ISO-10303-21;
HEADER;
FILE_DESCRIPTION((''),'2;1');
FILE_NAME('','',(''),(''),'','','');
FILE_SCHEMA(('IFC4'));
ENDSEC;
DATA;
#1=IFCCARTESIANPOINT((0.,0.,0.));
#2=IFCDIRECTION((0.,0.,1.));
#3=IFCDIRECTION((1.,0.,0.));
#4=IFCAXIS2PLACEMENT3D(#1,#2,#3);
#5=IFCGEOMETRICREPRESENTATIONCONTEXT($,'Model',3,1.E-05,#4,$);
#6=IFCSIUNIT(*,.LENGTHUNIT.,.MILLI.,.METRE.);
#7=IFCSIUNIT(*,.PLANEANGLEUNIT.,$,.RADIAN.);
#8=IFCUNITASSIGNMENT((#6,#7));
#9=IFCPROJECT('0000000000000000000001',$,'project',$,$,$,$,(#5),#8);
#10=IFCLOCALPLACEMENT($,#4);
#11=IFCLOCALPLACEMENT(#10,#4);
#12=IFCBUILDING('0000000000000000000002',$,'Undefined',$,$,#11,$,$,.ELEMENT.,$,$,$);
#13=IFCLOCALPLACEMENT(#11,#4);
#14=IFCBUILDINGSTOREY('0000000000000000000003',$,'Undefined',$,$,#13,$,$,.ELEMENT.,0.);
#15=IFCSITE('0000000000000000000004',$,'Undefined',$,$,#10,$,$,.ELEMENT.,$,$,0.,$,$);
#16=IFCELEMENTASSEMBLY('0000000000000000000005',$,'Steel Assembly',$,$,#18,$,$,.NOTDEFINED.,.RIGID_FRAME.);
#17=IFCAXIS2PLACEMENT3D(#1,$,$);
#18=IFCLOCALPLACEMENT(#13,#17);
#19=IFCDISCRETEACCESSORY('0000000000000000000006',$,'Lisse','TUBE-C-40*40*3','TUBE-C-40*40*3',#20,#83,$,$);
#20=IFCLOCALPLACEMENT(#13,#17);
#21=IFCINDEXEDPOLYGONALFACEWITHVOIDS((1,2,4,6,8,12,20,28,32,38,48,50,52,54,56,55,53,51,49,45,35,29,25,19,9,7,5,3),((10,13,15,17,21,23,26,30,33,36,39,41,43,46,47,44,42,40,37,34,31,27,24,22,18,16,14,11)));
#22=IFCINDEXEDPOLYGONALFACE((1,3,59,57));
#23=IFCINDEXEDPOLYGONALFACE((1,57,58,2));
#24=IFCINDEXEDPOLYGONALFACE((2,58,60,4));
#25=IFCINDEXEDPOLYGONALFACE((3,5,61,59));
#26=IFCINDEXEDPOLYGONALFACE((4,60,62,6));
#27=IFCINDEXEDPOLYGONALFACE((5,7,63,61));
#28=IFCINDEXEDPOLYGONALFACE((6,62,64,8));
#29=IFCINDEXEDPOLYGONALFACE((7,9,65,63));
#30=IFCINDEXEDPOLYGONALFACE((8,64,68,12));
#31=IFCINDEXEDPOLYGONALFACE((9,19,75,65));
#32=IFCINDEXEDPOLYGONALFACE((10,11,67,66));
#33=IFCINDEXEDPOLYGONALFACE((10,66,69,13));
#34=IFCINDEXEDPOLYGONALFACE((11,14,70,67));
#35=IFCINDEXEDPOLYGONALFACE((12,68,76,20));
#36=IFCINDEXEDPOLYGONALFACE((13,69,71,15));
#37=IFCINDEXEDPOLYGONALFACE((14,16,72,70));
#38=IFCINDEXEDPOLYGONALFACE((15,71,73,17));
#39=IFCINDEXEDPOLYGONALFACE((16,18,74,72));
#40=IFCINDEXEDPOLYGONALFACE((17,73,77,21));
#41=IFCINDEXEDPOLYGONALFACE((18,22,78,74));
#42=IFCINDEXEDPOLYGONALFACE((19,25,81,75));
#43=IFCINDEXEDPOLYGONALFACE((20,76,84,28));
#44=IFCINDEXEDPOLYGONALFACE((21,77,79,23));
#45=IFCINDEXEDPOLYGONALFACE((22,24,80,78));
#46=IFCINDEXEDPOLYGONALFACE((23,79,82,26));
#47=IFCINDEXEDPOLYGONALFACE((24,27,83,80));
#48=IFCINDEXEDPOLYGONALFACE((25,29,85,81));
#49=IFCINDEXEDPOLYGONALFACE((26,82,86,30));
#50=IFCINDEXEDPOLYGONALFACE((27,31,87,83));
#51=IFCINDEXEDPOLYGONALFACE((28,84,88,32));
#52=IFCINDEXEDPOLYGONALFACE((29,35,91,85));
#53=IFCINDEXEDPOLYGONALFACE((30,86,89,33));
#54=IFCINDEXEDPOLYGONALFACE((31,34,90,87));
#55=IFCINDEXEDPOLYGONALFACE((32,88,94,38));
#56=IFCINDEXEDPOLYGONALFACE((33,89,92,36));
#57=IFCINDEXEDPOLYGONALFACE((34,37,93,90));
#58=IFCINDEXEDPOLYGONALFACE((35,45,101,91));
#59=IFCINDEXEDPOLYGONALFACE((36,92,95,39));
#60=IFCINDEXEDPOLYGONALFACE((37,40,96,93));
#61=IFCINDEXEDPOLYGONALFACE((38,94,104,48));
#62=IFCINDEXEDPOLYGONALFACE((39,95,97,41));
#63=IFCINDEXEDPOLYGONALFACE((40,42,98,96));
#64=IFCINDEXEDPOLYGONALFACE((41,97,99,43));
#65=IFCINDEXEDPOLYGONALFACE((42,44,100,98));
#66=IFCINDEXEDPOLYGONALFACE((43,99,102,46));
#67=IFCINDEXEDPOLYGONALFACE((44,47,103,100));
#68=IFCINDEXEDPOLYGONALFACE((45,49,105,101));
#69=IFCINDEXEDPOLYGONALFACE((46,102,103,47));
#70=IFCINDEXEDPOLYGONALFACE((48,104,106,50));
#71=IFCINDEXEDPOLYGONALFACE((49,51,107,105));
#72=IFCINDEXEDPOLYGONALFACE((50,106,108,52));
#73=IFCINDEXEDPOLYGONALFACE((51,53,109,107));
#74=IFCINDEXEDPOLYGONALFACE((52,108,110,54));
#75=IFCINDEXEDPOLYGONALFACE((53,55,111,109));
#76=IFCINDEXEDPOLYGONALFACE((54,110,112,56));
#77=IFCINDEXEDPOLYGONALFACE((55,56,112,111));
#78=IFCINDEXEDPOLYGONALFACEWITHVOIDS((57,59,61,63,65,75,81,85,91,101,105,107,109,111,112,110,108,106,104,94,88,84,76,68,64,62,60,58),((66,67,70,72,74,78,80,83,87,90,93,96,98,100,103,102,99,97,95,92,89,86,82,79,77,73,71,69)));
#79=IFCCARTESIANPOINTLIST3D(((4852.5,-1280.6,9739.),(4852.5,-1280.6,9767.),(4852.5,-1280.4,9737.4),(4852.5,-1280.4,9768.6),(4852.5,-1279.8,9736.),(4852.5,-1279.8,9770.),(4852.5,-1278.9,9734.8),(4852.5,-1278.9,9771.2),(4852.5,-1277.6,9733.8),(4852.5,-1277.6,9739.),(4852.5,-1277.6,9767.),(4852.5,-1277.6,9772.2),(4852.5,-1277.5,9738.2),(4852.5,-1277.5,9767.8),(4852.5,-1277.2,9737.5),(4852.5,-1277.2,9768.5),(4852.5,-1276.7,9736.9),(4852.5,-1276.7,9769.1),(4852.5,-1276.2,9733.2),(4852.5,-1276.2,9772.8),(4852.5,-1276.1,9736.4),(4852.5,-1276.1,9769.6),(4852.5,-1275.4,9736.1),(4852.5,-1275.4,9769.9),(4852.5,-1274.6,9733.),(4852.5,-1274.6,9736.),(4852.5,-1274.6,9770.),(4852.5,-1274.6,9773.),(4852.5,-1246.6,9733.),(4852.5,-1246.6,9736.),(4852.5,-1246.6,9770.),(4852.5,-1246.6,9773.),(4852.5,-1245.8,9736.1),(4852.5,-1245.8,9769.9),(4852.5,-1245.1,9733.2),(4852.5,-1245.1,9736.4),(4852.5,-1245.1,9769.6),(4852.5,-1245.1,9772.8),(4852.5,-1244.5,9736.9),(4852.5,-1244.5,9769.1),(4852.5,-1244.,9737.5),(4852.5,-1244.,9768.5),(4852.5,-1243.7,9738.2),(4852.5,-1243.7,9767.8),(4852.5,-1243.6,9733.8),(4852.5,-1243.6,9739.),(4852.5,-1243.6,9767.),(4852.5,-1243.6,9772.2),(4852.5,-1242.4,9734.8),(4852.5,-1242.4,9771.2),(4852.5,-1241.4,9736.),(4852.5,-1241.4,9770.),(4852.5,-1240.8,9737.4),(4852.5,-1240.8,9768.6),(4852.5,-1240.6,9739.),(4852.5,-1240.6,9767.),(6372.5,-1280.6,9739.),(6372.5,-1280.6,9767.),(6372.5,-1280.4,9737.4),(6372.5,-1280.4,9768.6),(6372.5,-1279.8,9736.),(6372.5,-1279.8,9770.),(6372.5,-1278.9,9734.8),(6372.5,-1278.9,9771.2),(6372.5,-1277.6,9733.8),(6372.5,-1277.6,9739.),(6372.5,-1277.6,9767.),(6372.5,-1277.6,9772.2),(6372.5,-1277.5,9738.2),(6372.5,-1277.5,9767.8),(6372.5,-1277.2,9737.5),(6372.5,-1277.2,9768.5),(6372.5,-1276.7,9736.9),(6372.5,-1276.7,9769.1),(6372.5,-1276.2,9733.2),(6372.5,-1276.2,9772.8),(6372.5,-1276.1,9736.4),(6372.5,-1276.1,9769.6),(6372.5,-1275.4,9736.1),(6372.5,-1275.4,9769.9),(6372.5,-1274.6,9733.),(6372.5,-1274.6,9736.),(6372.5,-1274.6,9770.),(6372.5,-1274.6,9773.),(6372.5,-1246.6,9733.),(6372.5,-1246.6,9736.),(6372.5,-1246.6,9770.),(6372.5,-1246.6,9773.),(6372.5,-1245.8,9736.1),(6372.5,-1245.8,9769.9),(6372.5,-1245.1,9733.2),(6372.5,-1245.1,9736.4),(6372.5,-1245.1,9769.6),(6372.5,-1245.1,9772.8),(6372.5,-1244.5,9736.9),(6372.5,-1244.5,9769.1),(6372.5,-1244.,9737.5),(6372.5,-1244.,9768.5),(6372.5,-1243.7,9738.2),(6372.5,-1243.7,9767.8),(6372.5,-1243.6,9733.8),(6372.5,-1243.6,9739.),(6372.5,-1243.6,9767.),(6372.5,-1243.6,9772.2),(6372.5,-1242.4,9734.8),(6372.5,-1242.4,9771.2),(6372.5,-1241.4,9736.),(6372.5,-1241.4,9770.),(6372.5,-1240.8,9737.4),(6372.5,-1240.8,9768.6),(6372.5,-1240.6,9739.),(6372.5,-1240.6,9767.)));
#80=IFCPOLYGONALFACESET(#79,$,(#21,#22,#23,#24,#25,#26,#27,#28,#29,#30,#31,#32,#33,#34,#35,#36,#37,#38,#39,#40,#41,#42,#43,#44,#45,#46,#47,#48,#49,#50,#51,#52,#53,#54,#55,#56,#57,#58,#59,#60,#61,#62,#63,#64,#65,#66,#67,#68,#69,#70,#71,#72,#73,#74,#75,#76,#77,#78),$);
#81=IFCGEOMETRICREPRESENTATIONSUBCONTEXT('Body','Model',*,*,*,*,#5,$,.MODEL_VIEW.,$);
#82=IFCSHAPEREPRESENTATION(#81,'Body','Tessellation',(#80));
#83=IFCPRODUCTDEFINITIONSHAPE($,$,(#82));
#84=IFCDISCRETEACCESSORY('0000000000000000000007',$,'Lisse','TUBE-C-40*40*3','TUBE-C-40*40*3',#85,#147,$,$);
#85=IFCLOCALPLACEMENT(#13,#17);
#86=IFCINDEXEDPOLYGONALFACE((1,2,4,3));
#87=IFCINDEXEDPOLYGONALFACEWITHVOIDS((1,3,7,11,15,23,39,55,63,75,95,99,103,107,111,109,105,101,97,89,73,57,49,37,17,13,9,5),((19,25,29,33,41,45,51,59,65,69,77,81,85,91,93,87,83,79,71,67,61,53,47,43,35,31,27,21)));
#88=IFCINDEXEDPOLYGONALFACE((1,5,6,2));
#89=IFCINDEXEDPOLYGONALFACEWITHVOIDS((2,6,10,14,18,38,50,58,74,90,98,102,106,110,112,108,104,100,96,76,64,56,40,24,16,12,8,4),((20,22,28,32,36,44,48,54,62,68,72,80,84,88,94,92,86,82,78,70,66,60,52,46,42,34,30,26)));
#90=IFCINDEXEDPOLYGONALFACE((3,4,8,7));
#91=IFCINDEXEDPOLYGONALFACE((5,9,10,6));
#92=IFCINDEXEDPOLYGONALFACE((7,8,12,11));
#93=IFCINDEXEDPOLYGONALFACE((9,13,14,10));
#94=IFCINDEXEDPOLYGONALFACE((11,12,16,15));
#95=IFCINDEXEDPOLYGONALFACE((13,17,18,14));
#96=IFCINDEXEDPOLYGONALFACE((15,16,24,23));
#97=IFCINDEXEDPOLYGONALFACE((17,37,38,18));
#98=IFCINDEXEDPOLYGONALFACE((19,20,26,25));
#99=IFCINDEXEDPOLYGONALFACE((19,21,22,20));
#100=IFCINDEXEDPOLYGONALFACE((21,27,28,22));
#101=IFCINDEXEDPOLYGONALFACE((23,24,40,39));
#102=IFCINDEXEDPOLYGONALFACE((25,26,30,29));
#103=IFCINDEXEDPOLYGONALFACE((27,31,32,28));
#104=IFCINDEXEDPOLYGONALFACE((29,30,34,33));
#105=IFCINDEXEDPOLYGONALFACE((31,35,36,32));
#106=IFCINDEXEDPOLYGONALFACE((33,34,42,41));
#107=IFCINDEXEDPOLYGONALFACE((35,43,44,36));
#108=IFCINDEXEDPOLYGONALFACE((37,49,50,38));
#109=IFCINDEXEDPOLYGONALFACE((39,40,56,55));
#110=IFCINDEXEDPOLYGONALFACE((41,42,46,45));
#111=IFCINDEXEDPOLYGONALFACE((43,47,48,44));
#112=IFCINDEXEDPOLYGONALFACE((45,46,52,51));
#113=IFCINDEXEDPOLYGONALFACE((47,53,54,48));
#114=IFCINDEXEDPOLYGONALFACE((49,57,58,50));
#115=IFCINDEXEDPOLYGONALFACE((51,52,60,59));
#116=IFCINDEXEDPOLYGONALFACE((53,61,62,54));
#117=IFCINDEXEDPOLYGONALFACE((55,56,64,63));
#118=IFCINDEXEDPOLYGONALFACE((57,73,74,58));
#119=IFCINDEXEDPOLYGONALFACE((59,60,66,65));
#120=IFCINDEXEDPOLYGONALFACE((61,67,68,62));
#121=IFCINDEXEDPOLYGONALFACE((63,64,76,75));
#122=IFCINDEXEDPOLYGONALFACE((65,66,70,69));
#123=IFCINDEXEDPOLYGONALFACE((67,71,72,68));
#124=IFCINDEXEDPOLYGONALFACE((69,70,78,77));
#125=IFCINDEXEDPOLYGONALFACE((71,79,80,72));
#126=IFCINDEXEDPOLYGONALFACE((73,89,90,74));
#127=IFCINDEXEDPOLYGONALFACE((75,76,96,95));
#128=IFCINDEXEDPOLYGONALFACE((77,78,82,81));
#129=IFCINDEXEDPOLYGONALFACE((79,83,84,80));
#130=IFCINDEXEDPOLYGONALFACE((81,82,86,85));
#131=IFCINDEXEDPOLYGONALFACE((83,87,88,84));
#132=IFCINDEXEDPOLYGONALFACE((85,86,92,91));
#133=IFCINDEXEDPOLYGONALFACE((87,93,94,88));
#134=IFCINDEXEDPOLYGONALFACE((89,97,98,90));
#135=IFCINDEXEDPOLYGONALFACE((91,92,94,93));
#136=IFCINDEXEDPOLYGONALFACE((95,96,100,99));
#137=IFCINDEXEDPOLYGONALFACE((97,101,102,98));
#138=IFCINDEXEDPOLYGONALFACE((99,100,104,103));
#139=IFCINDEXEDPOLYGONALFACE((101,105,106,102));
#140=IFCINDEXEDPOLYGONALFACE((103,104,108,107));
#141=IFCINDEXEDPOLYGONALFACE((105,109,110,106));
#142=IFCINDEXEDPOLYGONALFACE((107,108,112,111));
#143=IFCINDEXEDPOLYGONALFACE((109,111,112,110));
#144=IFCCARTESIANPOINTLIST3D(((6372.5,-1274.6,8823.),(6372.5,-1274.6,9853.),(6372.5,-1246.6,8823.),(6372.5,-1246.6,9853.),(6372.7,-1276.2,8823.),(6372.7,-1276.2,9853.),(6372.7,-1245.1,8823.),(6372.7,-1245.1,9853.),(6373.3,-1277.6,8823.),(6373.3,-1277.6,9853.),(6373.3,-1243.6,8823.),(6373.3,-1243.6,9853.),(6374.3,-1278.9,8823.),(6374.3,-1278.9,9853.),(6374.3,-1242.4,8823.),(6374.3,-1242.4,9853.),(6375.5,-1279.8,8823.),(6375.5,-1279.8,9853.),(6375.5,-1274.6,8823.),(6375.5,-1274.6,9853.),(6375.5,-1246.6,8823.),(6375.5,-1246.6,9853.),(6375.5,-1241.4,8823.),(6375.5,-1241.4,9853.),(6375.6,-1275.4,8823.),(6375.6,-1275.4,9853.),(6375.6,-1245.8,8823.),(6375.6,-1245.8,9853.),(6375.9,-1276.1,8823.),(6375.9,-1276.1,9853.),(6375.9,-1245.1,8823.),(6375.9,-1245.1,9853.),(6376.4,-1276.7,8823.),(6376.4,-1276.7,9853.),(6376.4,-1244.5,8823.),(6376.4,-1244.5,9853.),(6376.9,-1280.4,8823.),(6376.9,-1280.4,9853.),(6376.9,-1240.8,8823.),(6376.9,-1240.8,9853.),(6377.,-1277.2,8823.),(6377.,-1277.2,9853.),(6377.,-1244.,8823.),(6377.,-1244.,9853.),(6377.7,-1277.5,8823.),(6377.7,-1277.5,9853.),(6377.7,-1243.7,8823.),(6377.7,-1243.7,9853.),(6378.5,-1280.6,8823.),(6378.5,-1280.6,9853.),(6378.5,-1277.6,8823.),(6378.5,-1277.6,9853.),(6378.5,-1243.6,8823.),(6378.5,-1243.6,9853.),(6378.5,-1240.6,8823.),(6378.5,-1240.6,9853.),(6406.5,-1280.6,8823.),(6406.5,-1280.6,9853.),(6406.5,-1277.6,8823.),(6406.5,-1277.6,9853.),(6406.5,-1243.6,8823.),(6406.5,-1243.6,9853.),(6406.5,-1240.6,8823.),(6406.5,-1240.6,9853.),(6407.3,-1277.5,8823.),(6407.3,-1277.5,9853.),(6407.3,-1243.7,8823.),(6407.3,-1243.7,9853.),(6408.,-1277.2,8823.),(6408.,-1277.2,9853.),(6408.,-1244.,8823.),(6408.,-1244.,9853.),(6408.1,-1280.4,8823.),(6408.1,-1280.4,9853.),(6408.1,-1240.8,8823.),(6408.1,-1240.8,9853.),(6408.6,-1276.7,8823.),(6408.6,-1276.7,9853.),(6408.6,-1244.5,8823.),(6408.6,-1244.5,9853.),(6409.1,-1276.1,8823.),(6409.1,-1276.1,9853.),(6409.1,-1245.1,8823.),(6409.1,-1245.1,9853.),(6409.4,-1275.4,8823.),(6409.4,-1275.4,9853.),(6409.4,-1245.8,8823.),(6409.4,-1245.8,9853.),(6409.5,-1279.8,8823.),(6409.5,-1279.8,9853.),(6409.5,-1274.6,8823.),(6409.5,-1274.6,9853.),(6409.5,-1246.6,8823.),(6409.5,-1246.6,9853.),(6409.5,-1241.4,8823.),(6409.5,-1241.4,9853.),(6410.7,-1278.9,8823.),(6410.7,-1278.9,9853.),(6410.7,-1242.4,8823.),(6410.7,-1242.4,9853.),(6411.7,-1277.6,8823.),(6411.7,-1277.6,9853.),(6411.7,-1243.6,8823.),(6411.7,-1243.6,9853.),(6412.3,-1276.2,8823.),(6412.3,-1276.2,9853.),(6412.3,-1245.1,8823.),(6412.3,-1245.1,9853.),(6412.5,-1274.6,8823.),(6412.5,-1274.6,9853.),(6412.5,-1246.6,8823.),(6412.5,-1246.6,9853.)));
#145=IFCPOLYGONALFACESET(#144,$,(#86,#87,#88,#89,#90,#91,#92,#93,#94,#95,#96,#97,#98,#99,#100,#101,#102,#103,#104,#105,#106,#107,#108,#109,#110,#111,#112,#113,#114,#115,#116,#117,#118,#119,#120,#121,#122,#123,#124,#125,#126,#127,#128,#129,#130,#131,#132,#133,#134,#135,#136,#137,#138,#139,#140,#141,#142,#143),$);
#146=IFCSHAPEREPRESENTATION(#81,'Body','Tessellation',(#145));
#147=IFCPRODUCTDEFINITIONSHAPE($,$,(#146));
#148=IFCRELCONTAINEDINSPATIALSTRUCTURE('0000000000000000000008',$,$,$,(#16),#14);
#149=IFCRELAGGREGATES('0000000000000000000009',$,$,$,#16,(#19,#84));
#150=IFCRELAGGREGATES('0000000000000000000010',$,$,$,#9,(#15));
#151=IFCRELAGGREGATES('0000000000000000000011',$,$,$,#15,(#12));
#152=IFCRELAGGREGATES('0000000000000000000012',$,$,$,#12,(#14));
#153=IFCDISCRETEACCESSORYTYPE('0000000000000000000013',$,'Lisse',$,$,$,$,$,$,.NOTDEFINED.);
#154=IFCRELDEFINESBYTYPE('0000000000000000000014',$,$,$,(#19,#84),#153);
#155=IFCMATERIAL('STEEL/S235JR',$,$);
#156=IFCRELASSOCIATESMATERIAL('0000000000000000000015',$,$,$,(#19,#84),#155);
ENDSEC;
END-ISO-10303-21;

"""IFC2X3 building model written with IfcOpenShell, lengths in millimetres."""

from ifc_helpers import new_model, si_unit, frame, origin_with_axes, origin_2d_with_axis, place, context, subcontext, project, spatial, hollow_rectangle, extrude, material, type_object, element, aggregate, save


model = new_model("IFC2X3")

# Units and contexts
model_context = context("Model", 3, precision=1e-05, world=origin_with_axes())
body_context = subcontext(model_context, "Body", "Model", "MODEL_VIEW")
ifc_project = project(units=[si_unit("LENGTHUNIT", "METRE", prefix="MILLI"), si_unit("PLANEANGLEUNIT", "RADIAN")], contexts=[model_context])

# Site, building, storey
site_placement = place(None, origin_with_axes())
site = spatial("IfcSite", under=ifc_project, at=site_placement, Name="Undefined", CompositionType="ELEMENT", RefElevation=0.0)
building_placement = place(site_placement, origin_with_axes())
building = spatial("IfcBuilding", under=site, at=building_placement, Name="Undefined", CompositionType="ELEMENT")
storey_placement = place(building_placement, origin_with_axes())
storey = spatial("IfcBuildingStorey", under=building, at=storey_placement, Name="Undefined", CompositionType="ELEMENT", Elevation=0.0)

# Element assembly
assembly_1_placement = place(storey_placement, origin_with_axes())
assembly_1 = element("IfcElementAssembly", 1, at=assembly_1_placement, inside=storey, Name="Steel Assembly", AssemblyPlace="NOTDEFINED", PredefinedType="RIGID_FRAME")
ifc_material_1 = material(Name="STEEL/S235JR")

# Discrete accessories
discrete_accessory_type_1 = type_object("IfcDiscreteAccessoryType", Name="Lisse")
discrete_accessory_1_placement = place(assembly_1_placement, frame((6372.5, -1260.6, 9753.0), z_axis=(0.0, 1.0, 0.0), x_axis=(-1.0, 0.0, 0.0)))
discrete_accessory_1 = element("IfcDiscreteAccessory", 2, at=discrete_accessory_1_placement, type_object=discrete_accessory_type_1, material=ifc_material_1, Name="Lisse", Description="TUBE-C-40*40*3", ObjectType="TUBE-C-40*40*3", context=body_context, shape_type="SweptSolid", body=[
    extrude(hollow_rectangle(XDim=40.0, YDim=40.0, WallThickness=3.0, InnerFilletRadius=3.0, OuterFilletRadius=6.0, at=origin_2d_with_axis()), frame((1520.0, 0.0, 0.0), z_axis=(-1.0, 0.0, 0.0), x_axis=(0.0, -1.0, 0.0)), (0.0, 0.0, 1.0), 1520.0),
])
discrete_accessory_2_placement = place(assembly_1_placement, frame((6392.5, -1260.6, 9853.0), z_axis=(0.0, 1.0, 0.0), x_axis=(0.0, 0.0, -1.0)))
discrete_accessory_2 = element("IfcDiscreteAccessory", 3, at=discrete_accessory_2_placement, type_object=discrete_accessory_type_1, material=ifc_material_1, Name="Lisse", Description="TUBE-C-40*40*3", ObjectType="TUBE-C-40*40*3", context=body_context, shape_type="SweptSolid", body=[
    extrude(hollow_rectangle(XDim=40.0, YDim=40.0, WallThickness=3.0, InnerFilletRadius=3.0, OuterFilletRadius=6.0, at=origin_2d_with_axis()), frame((1030.0, 0.0, 0.0), z_axis=(-1.0, 0.0, 0.0), x_axis=(0.0, -1.0, 0.0)), (0.0, 0.0, 1.0), 1030.0),
])
aggregate(assembly_1, [discrete_accessory_1, discrete_accessory_2])

save(model, "model.ifc")
